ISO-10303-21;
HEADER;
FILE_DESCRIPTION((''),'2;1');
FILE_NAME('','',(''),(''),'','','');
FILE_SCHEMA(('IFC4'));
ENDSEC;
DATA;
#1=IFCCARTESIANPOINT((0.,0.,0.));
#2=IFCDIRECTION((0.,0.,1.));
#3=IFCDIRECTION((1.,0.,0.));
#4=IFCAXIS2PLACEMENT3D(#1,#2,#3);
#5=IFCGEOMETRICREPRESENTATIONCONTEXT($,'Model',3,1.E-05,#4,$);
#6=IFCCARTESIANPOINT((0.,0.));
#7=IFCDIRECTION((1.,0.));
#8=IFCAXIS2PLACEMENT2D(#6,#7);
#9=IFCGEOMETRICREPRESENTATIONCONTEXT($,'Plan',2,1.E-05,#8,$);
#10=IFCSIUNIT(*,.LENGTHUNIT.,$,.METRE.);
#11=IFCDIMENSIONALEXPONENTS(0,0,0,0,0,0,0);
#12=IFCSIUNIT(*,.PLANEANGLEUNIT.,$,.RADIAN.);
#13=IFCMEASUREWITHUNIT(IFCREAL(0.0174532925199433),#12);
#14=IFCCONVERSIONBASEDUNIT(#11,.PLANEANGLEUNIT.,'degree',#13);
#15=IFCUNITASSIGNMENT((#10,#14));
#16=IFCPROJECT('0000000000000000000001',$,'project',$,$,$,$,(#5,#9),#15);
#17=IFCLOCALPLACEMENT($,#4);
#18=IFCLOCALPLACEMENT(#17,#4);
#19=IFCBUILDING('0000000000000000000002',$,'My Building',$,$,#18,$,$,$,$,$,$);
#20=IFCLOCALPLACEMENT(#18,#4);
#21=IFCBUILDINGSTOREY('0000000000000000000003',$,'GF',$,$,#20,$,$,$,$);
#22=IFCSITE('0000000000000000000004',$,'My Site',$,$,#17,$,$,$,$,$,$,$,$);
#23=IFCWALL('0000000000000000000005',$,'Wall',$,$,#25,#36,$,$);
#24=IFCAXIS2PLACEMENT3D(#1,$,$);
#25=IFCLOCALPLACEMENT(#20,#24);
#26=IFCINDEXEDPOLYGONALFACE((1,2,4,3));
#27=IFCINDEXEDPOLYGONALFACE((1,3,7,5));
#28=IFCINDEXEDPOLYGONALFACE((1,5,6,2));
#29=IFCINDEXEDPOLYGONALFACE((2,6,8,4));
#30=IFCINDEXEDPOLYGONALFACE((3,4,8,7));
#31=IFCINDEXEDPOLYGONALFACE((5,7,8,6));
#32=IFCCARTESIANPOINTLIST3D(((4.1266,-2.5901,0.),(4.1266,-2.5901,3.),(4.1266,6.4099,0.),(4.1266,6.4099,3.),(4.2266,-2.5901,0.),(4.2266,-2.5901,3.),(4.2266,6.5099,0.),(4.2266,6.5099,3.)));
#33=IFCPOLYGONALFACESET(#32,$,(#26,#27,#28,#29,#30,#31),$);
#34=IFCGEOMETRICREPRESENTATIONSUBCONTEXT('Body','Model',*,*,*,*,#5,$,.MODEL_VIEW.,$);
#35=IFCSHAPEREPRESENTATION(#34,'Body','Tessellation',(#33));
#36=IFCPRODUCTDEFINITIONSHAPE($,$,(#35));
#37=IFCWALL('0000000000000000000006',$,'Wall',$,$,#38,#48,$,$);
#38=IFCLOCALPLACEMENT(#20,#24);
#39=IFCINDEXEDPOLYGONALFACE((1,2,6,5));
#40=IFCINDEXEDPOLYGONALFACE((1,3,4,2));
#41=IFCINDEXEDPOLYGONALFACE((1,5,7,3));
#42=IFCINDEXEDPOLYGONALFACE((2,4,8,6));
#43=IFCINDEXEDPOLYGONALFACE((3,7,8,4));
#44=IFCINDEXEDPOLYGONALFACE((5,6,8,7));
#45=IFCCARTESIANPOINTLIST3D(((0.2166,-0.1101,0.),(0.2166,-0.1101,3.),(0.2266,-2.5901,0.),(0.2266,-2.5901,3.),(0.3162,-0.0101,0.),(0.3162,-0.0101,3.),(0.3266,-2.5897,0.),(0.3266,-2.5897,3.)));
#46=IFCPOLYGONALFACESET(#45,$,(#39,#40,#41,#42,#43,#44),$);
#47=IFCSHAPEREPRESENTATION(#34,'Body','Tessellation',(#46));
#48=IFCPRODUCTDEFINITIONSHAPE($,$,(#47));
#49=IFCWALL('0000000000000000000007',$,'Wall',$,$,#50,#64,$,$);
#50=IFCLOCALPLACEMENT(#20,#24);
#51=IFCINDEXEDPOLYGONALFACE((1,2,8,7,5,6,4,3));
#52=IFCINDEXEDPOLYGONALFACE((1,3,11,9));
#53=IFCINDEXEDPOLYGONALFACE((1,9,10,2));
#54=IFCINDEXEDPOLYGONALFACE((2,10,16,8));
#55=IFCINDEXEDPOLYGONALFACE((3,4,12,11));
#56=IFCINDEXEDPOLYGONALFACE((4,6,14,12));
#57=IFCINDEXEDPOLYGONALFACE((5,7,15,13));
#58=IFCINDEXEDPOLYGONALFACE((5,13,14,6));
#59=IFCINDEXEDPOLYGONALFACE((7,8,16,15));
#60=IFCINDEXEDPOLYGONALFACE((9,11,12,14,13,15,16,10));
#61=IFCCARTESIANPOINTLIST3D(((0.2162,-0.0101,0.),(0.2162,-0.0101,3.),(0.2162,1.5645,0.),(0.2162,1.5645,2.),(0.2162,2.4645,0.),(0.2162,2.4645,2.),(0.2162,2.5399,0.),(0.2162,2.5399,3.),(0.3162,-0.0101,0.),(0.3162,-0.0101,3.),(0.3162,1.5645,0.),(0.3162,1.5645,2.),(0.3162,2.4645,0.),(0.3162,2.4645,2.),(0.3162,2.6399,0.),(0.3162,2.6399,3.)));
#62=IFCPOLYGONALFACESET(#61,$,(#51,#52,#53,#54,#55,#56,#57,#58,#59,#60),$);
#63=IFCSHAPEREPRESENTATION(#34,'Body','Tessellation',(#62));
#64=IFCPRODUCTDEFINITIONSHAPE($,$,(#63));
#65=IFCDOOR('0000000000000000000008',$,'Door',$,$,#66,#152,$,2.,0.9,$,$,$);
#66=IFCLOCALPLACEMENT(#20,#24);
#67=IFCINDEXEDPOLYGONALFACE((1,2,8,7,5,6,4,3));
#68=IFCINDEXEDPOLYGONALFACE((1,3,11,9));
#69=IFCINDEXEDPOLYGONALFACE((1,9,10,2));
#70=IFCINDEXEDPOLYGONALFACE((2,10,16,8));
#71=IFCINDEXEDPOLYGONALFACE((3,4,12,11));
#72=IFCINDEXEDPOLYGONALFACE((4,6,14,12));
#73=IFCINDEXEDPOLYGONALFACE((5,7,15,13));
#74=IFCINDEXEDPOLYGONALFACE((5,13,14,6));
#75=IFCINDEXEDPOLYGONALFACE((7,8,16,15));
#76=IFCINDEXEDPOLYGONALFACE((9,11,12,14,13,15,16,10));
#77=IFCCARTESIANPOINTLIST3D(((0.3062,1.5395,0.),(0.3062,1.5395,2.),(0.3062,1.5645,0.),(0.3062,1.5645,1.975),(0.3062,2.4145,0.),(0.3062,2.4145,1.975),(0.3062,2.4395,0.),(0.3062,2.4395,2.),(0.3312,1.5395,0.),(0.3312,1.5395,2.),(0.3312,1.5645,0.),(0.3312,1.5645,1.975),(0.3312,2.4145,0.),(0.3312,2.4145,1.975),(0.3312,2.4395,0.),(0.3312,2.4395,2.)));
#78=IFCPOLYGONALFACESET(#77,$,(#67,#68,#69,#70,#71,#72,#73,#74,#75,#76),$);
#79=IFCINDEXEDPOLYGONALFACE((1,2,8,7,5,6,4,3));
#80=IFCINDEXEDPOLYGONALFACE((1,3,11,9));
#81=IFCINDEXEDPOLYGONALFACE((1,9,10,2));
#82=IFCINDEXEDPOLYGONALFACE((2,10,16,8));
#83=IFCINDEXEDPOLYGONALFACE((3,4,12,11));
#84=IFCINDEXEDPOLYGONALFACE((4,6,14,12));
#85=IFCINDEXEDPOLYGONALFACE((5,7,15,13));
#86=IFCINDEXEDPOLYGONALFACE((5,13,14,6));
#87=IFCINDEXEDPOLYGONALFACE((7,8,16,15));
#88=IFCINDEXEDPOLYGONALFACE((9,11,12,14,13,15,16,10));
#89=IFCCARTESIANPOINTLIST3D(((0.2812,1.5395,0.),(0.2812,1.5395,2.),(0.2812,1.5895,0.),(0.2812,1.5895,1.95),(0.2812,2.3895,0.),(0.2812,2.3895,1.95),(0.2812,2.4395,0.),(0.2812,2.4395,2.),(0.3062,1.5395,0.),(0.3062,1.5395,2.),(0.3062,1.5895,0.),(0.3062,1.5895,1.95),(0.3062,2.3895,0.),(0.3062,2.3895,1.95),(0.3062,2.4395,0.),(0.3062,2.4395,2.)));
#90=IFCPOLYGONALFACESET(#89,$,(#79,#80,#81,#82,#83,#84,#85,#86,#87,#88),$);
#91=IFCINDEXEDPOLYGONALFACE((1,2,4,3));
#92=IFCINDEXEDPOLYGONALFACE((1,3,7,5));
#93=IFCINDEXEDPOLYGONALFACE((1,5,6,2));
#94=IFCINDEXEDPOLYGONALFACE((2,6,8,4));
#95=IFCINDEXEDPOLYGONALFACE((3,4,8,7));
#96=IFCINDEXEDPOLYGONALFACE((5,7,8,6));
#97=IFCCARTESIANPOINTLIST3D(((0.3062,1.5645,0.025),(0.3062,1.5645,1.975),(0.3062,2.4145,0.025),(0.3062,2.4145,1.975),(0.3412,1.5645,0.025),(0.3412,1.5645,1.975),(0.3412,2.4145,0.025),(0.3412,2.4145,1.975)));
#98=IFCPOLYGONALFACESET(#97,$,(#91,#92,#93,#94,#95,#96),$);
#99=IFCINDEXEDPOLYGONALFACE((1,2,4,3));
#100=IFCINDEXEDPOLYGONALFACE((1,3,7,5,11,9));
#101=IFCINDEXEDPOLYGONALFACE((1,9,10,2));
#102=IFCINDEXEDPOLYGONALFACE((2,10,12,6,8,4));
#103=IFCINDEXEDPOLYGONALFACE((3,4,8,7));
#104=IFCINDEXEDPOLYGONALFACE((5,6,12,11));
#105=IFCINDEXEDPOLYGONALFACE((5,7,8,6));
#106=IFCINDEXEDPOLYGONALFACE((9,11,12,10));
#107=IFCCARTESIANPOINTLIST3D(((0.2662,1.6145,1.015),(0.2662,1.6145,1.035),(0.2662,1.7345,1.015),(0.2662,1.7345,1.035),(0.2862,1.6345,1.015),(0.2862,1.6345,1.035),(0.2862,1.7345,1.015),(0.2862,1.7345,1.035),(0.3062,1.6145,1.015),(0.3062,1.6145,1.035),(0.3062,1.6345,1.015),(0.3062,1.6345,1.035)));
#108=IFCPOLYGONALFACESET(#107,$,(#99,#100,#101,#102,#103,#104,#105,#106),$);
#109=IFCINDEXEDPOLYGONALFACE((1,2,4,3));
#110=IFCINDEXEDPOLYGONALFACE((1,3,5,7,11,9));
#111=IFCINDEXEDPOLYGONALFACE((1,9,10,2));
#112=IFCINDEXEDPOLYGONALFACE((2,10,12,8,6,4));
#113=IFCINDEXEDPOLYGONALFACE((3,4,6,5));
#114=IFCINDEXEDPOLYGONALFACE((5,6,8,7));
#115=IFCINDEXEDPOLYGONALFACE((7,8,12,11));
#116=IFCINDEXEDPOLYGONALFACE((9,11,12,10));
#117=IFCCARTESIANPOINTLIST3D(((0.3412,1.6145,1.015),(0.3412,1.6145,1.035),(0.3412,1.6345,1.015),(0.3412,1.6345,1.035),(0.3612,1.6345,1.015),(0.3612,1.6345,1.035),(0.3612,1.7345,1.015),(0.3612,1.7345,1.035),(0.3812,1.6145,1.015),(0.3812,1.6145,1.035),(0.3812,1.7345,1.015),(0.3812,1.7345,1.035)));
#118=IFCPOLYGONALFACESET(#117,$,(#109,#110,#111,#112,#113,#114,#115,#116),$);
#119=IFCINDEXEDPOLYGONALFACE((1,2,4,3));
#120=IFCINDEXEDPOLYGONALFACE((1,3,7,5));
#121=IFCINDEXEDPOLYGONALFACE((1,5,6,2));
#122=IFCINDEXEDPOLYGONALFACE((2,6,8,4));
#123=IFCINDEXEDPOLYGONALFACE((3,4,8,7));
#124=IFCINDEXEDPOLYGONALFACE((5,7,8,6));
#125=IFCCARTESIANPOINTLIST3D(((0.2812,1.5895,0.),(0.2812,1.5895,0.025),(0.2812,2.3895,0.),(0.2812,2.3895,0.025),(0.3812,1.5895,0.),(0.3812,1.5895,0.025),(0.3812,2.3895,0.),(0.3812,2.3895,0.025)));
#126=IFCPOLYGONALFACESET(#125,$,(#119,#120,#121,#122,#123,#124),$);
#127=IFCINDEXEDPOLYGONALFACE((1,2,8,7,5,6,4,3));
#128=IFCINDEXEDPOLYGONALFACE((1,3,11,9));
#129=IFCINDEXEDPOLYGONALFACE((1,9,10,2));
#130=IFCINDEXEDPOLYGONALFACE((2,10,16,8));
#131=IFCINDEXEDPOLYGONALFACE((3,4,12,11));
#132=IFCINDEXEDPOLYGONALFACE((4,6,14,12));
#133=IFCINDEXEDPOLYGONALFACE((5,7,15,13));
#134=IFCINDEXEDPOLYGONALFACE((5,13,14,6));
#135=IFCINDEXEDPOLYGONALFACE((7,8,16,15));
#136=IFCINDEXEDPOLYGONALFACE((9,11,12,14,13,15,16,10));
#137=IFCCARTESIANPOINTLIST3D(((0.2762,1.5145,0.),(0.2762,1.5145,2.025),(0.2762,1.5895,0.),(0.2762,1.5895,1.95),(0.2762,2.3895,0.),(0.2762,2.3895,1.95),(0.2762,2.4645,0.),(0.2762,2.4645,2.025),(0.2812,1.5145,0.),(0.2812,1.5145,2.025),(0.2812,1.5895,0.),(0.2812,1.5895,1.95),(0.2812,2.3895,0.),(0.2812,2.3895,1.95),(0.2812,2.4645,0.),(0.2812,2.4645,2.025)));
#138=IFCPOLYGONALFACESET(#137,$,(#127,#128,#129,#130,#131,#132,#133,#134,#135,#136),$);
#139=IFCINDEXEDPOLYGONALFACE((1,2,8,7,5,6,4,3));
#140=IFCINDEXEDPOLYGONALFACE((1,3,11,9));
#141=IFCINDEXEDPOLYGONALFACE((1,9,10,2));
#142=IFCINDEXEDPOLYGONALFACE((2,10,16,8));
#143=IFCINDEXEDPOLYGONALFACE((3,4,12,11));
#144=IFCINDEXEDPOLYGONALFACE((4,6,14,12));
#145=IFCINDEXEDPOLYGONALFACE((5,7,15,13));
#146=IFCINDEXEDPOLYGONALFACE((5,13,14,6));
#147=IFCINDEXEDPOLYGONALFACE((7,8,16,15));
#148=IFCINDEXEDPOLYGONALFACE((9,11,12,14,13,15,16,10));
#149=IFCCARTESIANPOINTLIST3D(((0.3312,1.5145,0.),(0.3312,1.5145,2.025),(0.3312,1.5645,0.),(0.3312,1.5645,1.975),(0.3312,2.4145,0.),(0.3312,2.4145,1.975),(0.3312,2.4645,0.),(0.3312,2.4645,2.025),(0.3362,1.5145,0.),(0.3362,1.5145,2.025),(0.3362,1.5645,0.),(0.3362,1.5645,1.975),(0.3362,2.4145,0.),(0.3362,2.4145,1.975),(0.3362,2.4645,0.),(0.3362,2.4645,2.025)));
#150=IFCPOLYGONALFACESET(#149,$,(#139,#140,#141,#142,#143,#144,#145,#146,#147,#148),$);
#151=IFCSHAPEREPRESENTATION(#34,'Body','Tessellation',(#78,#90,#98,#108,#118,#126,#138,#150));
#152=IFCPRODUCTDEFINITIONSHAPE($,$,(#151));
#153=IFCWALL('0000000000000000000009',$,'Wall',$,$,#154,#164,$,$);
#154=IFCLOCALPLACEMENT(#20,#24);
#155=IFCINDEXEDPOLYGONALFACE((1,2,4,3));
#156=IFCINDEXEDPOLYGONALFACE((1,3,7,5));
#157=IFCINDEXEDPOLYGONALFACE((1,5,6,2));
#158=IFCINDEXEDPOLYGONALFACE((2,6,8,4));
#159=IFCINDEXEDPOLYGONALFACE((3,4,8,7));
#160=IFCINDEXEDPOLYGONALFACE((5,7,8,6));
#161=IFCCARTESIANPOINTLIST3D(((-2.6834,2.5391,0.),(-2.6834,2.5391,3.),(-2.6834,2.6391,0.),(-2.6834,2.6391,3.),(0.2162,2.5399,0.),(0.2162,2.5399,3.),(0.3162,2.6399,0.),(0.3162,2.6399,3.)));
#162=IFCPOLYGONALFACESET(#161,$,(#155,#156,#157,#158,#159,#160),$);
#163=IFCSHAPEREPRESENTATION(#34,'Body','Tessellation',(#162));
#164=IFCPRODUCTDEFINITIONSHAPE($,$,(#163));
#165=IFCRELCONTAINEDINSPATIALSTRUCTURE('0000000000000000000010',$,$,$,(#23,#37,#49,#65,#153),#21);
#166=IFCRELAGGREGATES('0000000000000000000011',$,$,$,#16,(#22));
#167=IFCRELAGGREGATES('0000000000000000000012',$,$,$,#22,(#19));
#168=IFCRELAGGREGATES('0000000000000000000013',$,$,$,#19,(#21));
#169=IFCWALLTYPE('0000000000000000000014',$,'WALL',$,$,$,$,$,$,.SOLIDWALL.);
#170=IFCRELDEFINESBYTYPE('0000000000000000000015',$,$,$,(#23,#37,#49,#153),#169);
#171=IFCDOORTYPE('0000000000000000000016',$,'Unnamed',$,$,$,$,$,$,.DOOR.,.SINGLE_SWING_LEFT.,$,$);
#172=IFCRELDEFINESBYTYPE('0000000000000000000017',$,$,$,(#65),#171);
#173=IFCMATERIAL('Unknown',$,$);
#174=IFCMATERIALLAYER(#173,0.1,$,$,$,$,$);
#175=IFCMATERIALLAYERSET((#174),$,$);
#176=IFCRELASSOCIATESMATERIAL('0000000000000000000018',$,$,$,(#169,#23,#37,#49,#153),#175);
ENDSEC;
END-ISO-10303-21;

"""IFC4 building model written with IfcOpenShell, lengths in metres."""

from ifc_helpers import new_model, entity, si_unit, converted_unit, frame, origin_with_axes, origin_2d_with_axis, place, context, subcontext, project, spatial, line, indexed_curve, outline, extrude, shape, source, transform, mapped, material, layer, layer_set, layer_usage, type_object, type_shapes, element, fill, save


model = new_model("IFC4")

# Units and contexts
model_context = context("Model", 3, precision=1e-05, world=origin_with_axes())
plan_context = context("Plan", 2, precision=1e-05, world=origin_2d_with_axis())
body_context_1 = subcontext(model_context, "Body", "Model", "MODEL_VIEW")
body_context_2 = subcontext(plan_context, "Body", "Plan", "PLAN_VIEW")
ifc_project = project(units=[si_unit("LENGTHUNIT", "METRE"), converted_unit("PLANEANGLEUNIT", "degree", entity("IfcReal", 0.0174532925199433), si_unit("PLANEANGLEUNIT", "RADIAN"), dimensions=[0, 0, 0, 0, 0, 0, 0])], contexts=[model_context, plan_context])

# Site, building, storey
site_placement = place(None, origin_with_axes())
site = spatial("IfcSite", under=ifc_project, at=site_placement, Name="My Site")
building_placement = place(site_placement, origin_with_axes())
building = spatial("IfcBuilding", under=site, at=building_placement, Name="My Building")
storey_placement = place(building_placement, origin_with_axes())
storey = spatial("IfcBuildingStorey", under=building, at=storey_placement, Name="GF")

# Shared definitions
ifc_material_1 = material(Name="Unknown")

# Shared definitions
ifc_layer_1 = layer(ifc_material_1, 0.1)
ifc_layer_set_1 = layer_set([ifc_layer_1])
wall_type = type_object("IfcWallType", Name="WALL", PredefinedType="SOLIDWALL", material=ifc_layer_set_1)
shared_shape_1 = source(origin_with_axes(), body_context_1, "Body", "SweptSolid", [
    extrude(outline(indexed_curve([(0.0, 0.0), (0.9, 0.0), (0.9, 2.0), (0.0, 2.0)], segments=[line(1, 2, 3, 4, 1)])), frame((0.0, -0.6, 0.0), z_axis=(0.0, -1.0, 0.0), x_axis=(1.0, 0.0, 0.0)), (0.0, 0.0, -1.0), 1.2),
])
door_type = type_object("IfcDoorType", Name="Unnamed", OperationType="SINGLE_SWING_LEFT", PredefinedType="DOOR")
shared_shape_2 = source(origin_with_axes(), body_context_1, "Body", "SweptSolid", [
    extrude(outline(indexed_curve([(0.0, 0.0), (0.0, 2.0), (0.9, 2.0), (0.9, 0.0), (0.875, 0.0), (0.875, 1.975), (0.025, 1.975), (0.025, 0.0)], segments=[line(1, 2, 3, 4, 5, 6, 7, 8, 1)])), frame((0.0, 0.025, 0.0), z_axis=(0.0, -1.0, 0.0), x_axis=(1.0, 0.0, 0.0)), (0.0, 0.0, -1.0), 0.025),
    extrude(outline(indexed_curve([(0.0, 0.0), (0.0, 2.0), (0.9, 2.0), (0.9, 0.0), (0.85, 0.0), (0.85, 1.95), (0.05, 1.95), (0.05, 0.0)], segments=[line(1, 2, 3, 4, 5, 6, 7, 8, 1)])), frame((0.0, 0.0, 0.0), z_axis=(0.0, -1.0, 0.0), x_axis=(1.0, 0.0, 0.0)), (0.0, 0.0, -1.0), 0.025),
    extrude(outline(indexed_curve([(0.0, 0.0), (0.85, 0.0), (0.85, 0.035), (0.0, 0.035)], segments=[line(1, 2, 3, 4, 1)])), frame((0.025, 0.025, 0.025), z_axis=(0.0, 0.0, 1.0), x_axis=(1.0, 0.0, 0.0)), (0.0, 0.0, 1.0), 1.95),
    extrude(outline(indexed_curve([(0.0, 0.0), (0.0, -0.04), (-0.12, -0.04), (-0.12, -0.02), (-0.02, -0.02), (-0.02, 0.0)], segments=[line(1, 2, 3, 4, 5, 6, 1)])), frame((0.825, 0.025, 1.015), z_axis=(0.0, 0.0, 1.0), x_axis=(1.0, 0.0, 0.0)), (0.0, 0.0, 1.0), 0.02),
    extrude(outline(indexed_curve([(0.0, 0.0), (0.0, 0.04), (-0.12, 0.04), (-0.12, 0.02), (-0.02, 0.02), (-0.02, 0.0)], segments=[line(1, 2, 3, 4, 5, 6, 1)])), frame((0.825, 0.06, 1.015), z_axis=(0.0, 0.0, 1.0), x_axis=(1.0, 0.0, 0.0)), (0.0, 0.0, 1.0), 0.02),
    extrude(outline(indexed_curve([(0.0, 0.0), (0.8, 0.0), (0.8, 0.1), (0.0, 0.1)], segments=[line(1, 2, 3, 4, 1)])), frame((0.05, 0.0, 0.0), z_axis=(0.0, 0.0, 1.0), x_axis=(1.0, 0.0, 0.0)), (0.0, 0.0, 1.0), 0.025),
    extrude(outline(indexed_curve([(0.0, 0.0), (0.0, 2.025), (0.95, 2.025), (0.95, 0.0), (0.875, 0.0), (0.875, 1.95), (0.075, 1.95), (0.075, 0.0)], segments=[line(1, 2, 3, 4, 5, 6, 7, 8, 1)])), frame((-0.025, -0.005, 0.0), z_axis=(0.0, -1.0, 0.0), x_axis=(1.0, 0.0, 0.0)), (0.0, 0.0, -1.0), 0.005),
    extrude(outline(indexed_curve([(0.0, 0.0), (0.0, 2.025), (0.95, 2.025), (0.95, 0.0), (0.9, 0.0), (0.9, 1.975), (0.05, 1.975), (0.05, 0.0)], segments=[line(1, 2, 3, 4, 5, 6, 7, 8, 1)])), frame((-0.025, 0.05, 0.0), z_axis=(0.0, -1.0, 0.0), x_axis=(1.0, 0.0, 0.0)), (0.0, 0.0, -1.0), 0.005),
])
shared_shape_3 = source(origin_with_axes(), body_context_2, "Body", "Curve2D", [
    entity("IfcIndexedPolyCurve", entity("IfcCartesianPointList2D", [[0.0, 0.0], [0.0, 0.05], [0.025, 0.05], [0.025, 0.025], [0.05, 0.025], [0.05, 0.0]]), [entity("IfcLineIndex", [1, 2, 3, 4, 5, 6, 1])]),
    entity("IfcIndexedPolyCurve", entity("IfcCartesianPointList2D", [[0.9, 0.0], [0.9, 0.05], [0.875, 0.05], [0.875, 0.025], [0.85, 0.025], [0.85, 0.0]]), [entity("IfcLineIndex", [1, 2, 3, 4, 5, 6, 1])]),
    entity("IfcTrimmedCurve", entity("IfcEllipse", entity("IfcAxis2Placement2D", entity("IfcCartesianPoint", [0.06, 0.05]), entity("IfcDirection", [1.0, 0.0])), 0.815, 0.85), [entity("IfcCartesianPoint", [0.875, 0.05])], [entity("IfcCartesianPoint", [0.06, 0.9])], True, "CARTESIAN"),
    entity("IfcIndexedPolyCurve", entity("IfcCartesianPointList2D", [[0.025, 0.05], [0.06, 0.05], [0.06, 0.9], [0.025, 0.9]]), [entity("IfcLineIndex", [1, 2, 3, 4, 1])]),
])
type_shapes(door_type, [shared_shape_2, shared_shape_3])

# Wall
ifc_layer_usage_1 = layer_usage(ifc_layer_set_1, "AXIS2", "POSITIVE", 0.0)
wall_1_placement = place(storey_placement, frame((4.2266, -2.5901, 0.0), z_axis=(0.0, 0.0, 1.0), x_axis=(0.0, 1.0, 0.0)))
element("IfcWall", 1, at=wall_1_placement, inside=storey, type_object=wall_type, material=ifc_layer_usage_1, Name="Wall", context=body_context_1, shape_type="SweptSolid", body=[
    extrude(outline(indexed_curve([(0.0, 0.0), (0.0, 0.1), (9.0, 0.1), (9.1, 0.0)], segments=[line(1, 2, 3, 4, 1)])), origin_with_axes(), (0.0, 0.0, 1.0), 3.0),
])

# Wall
ifc_layer_usage_2 = layer_usage(ifc_layer_set_1, "AXIS2", "POSITIVE", 0.0)
wall_2_placement = place(storey_placement, frame((0.2166, -0.1101, 0.0), z_axis=(0.0, 0.0, 1.0), x_axis=(0.004032, -0.999992, 0.0)))
element("IfcWall", 2, at=wall_2_placement, inside=storey, type_object=wall_type, material=ifc_layer_usage_2, Name="Wall", context=body_context_1, shape_type="SweptSolid", body=[
    extrude(outline(indexed_curve([(0.0, 0.0), (-0.0996, 0.1), (2.48, 0.1), (2.48, 0.0)], segments=[line(1, 2, 3, 4, 1)])), origin_with_axes(), (0.0, 0.0, 1.0), 3.0),
])

# Wall, opening, door
ifc_layer_usage_3 = layer_usage(ifc_layer_set_1, "AXIS2", "POSITIVE", 0.0)
wall_3_placement = place(storey_placement, frame((0.3162, -0.0101, 0.0), z_axis=(0.0, 0.0, 1.0), x_axis=(0.0, 1.0, 0.0)))
wall_3 = element("IfcWall", 3, at=wall_3_placement, inside=storey, type_object=wall_type, material=ifc_layer_usage_3, Name="Wall", context=body_context_1, shape_type="SweptSolid", body=[
    extrude(outline(indexed_curve([(0.0, 0.0), (0.0, 0.1), (2.55, 0.1), (2.65, 0.0)], segments=[line(1, 2, 3, 4, 1)])), origin_with_axes(), (0.0, 0.0, 1.0), 3.0),
])
opening_1_placement = place(wall_3_placement, frame((1.5746, 0.0, 0.0), z_axis=(0.0, 0.0, 1.0), x_axis=(1.0, 0.0, 0.0)))
opening_1 = element("IfcOpeningElement", 4, at=opening_1_placement, cuts=wall_3, PredefinedType="OPENING", context=body_context_1, shape_type="MappedRepresentation", body=[
    mapped(shared_shape_1, transform((0.0, 0.0, 0.0), x_axis=(1.0, 0.0, 0.0), y_axis=(0.0, 1.0, 0.0), z_axis=(0.0, 0.0, 1.0), scale=1.0)),
])
door_1_placement = place(opening_1_placement, frame((0.875, 0.035, 0.0), z_axis=(0.0, 0.0, 1.0), x_axis=(-1.0, 0.0, 0.0)))
door_1 = element("IfcDoor", 5, at=door_1_placement, inside=storey, type_object=door_type, Name="Door", OverallHeight=2.0, OverallWidth=0.9, shapes=[
    shape(body_context_1, "Body", "MappedRepresentation", [mapped(shared_shape_2, transform((0.0, 0.0, 0.0), x_axis=(1.0, 0.0, 0.0), y_axis=(0.0, 1.0, 0.0), z_axis=(0.0, 0.0, 1.0), scale=1.0))]),
    shape(body_context_2, "Body", "MappedRepresentation", [mapped(shared_shape_3, transform((0.0, 0.0, 0.0), x_axis=(1.0, 0.0, 0.0), y_axis=(0.0, 1.0, 0.0), z_axis=(0.0, 0.0, 1.0), scale=1.0))]),
])
fill(opening_1, door_1)

# Wall
ifc_layer_usage_4 = layer_usage(ifc_layer_set_1, "AXIS2", "POSITIVE", 0.0)
wall_4_placement = place(storey_placement, frame((0.3162, 2.6399, 0.0), z_axis=(0.0, 0.0, 1.0), x_axis=(-1.0, -0.00025, 0.0)))
element("IfcWall", 6, at=wall_4_placement, inside=storey, type_object=wall_type, material=ifc_layer_usage_4, Name="Wall", context=body_context_1, shape_type="SweptSolid", body=[
    extrude(outline(indexed_curve([(0.0, 0.0), (0.1, 0.1), (2.9996, 0.1), (2.9996, 0.0)], segments=[line(1, 2, 3, 4, 1)])), origin_with_axes(), (0.0, 0.0, 1.0), 3.0),
])

save(model, "model.ifc")
